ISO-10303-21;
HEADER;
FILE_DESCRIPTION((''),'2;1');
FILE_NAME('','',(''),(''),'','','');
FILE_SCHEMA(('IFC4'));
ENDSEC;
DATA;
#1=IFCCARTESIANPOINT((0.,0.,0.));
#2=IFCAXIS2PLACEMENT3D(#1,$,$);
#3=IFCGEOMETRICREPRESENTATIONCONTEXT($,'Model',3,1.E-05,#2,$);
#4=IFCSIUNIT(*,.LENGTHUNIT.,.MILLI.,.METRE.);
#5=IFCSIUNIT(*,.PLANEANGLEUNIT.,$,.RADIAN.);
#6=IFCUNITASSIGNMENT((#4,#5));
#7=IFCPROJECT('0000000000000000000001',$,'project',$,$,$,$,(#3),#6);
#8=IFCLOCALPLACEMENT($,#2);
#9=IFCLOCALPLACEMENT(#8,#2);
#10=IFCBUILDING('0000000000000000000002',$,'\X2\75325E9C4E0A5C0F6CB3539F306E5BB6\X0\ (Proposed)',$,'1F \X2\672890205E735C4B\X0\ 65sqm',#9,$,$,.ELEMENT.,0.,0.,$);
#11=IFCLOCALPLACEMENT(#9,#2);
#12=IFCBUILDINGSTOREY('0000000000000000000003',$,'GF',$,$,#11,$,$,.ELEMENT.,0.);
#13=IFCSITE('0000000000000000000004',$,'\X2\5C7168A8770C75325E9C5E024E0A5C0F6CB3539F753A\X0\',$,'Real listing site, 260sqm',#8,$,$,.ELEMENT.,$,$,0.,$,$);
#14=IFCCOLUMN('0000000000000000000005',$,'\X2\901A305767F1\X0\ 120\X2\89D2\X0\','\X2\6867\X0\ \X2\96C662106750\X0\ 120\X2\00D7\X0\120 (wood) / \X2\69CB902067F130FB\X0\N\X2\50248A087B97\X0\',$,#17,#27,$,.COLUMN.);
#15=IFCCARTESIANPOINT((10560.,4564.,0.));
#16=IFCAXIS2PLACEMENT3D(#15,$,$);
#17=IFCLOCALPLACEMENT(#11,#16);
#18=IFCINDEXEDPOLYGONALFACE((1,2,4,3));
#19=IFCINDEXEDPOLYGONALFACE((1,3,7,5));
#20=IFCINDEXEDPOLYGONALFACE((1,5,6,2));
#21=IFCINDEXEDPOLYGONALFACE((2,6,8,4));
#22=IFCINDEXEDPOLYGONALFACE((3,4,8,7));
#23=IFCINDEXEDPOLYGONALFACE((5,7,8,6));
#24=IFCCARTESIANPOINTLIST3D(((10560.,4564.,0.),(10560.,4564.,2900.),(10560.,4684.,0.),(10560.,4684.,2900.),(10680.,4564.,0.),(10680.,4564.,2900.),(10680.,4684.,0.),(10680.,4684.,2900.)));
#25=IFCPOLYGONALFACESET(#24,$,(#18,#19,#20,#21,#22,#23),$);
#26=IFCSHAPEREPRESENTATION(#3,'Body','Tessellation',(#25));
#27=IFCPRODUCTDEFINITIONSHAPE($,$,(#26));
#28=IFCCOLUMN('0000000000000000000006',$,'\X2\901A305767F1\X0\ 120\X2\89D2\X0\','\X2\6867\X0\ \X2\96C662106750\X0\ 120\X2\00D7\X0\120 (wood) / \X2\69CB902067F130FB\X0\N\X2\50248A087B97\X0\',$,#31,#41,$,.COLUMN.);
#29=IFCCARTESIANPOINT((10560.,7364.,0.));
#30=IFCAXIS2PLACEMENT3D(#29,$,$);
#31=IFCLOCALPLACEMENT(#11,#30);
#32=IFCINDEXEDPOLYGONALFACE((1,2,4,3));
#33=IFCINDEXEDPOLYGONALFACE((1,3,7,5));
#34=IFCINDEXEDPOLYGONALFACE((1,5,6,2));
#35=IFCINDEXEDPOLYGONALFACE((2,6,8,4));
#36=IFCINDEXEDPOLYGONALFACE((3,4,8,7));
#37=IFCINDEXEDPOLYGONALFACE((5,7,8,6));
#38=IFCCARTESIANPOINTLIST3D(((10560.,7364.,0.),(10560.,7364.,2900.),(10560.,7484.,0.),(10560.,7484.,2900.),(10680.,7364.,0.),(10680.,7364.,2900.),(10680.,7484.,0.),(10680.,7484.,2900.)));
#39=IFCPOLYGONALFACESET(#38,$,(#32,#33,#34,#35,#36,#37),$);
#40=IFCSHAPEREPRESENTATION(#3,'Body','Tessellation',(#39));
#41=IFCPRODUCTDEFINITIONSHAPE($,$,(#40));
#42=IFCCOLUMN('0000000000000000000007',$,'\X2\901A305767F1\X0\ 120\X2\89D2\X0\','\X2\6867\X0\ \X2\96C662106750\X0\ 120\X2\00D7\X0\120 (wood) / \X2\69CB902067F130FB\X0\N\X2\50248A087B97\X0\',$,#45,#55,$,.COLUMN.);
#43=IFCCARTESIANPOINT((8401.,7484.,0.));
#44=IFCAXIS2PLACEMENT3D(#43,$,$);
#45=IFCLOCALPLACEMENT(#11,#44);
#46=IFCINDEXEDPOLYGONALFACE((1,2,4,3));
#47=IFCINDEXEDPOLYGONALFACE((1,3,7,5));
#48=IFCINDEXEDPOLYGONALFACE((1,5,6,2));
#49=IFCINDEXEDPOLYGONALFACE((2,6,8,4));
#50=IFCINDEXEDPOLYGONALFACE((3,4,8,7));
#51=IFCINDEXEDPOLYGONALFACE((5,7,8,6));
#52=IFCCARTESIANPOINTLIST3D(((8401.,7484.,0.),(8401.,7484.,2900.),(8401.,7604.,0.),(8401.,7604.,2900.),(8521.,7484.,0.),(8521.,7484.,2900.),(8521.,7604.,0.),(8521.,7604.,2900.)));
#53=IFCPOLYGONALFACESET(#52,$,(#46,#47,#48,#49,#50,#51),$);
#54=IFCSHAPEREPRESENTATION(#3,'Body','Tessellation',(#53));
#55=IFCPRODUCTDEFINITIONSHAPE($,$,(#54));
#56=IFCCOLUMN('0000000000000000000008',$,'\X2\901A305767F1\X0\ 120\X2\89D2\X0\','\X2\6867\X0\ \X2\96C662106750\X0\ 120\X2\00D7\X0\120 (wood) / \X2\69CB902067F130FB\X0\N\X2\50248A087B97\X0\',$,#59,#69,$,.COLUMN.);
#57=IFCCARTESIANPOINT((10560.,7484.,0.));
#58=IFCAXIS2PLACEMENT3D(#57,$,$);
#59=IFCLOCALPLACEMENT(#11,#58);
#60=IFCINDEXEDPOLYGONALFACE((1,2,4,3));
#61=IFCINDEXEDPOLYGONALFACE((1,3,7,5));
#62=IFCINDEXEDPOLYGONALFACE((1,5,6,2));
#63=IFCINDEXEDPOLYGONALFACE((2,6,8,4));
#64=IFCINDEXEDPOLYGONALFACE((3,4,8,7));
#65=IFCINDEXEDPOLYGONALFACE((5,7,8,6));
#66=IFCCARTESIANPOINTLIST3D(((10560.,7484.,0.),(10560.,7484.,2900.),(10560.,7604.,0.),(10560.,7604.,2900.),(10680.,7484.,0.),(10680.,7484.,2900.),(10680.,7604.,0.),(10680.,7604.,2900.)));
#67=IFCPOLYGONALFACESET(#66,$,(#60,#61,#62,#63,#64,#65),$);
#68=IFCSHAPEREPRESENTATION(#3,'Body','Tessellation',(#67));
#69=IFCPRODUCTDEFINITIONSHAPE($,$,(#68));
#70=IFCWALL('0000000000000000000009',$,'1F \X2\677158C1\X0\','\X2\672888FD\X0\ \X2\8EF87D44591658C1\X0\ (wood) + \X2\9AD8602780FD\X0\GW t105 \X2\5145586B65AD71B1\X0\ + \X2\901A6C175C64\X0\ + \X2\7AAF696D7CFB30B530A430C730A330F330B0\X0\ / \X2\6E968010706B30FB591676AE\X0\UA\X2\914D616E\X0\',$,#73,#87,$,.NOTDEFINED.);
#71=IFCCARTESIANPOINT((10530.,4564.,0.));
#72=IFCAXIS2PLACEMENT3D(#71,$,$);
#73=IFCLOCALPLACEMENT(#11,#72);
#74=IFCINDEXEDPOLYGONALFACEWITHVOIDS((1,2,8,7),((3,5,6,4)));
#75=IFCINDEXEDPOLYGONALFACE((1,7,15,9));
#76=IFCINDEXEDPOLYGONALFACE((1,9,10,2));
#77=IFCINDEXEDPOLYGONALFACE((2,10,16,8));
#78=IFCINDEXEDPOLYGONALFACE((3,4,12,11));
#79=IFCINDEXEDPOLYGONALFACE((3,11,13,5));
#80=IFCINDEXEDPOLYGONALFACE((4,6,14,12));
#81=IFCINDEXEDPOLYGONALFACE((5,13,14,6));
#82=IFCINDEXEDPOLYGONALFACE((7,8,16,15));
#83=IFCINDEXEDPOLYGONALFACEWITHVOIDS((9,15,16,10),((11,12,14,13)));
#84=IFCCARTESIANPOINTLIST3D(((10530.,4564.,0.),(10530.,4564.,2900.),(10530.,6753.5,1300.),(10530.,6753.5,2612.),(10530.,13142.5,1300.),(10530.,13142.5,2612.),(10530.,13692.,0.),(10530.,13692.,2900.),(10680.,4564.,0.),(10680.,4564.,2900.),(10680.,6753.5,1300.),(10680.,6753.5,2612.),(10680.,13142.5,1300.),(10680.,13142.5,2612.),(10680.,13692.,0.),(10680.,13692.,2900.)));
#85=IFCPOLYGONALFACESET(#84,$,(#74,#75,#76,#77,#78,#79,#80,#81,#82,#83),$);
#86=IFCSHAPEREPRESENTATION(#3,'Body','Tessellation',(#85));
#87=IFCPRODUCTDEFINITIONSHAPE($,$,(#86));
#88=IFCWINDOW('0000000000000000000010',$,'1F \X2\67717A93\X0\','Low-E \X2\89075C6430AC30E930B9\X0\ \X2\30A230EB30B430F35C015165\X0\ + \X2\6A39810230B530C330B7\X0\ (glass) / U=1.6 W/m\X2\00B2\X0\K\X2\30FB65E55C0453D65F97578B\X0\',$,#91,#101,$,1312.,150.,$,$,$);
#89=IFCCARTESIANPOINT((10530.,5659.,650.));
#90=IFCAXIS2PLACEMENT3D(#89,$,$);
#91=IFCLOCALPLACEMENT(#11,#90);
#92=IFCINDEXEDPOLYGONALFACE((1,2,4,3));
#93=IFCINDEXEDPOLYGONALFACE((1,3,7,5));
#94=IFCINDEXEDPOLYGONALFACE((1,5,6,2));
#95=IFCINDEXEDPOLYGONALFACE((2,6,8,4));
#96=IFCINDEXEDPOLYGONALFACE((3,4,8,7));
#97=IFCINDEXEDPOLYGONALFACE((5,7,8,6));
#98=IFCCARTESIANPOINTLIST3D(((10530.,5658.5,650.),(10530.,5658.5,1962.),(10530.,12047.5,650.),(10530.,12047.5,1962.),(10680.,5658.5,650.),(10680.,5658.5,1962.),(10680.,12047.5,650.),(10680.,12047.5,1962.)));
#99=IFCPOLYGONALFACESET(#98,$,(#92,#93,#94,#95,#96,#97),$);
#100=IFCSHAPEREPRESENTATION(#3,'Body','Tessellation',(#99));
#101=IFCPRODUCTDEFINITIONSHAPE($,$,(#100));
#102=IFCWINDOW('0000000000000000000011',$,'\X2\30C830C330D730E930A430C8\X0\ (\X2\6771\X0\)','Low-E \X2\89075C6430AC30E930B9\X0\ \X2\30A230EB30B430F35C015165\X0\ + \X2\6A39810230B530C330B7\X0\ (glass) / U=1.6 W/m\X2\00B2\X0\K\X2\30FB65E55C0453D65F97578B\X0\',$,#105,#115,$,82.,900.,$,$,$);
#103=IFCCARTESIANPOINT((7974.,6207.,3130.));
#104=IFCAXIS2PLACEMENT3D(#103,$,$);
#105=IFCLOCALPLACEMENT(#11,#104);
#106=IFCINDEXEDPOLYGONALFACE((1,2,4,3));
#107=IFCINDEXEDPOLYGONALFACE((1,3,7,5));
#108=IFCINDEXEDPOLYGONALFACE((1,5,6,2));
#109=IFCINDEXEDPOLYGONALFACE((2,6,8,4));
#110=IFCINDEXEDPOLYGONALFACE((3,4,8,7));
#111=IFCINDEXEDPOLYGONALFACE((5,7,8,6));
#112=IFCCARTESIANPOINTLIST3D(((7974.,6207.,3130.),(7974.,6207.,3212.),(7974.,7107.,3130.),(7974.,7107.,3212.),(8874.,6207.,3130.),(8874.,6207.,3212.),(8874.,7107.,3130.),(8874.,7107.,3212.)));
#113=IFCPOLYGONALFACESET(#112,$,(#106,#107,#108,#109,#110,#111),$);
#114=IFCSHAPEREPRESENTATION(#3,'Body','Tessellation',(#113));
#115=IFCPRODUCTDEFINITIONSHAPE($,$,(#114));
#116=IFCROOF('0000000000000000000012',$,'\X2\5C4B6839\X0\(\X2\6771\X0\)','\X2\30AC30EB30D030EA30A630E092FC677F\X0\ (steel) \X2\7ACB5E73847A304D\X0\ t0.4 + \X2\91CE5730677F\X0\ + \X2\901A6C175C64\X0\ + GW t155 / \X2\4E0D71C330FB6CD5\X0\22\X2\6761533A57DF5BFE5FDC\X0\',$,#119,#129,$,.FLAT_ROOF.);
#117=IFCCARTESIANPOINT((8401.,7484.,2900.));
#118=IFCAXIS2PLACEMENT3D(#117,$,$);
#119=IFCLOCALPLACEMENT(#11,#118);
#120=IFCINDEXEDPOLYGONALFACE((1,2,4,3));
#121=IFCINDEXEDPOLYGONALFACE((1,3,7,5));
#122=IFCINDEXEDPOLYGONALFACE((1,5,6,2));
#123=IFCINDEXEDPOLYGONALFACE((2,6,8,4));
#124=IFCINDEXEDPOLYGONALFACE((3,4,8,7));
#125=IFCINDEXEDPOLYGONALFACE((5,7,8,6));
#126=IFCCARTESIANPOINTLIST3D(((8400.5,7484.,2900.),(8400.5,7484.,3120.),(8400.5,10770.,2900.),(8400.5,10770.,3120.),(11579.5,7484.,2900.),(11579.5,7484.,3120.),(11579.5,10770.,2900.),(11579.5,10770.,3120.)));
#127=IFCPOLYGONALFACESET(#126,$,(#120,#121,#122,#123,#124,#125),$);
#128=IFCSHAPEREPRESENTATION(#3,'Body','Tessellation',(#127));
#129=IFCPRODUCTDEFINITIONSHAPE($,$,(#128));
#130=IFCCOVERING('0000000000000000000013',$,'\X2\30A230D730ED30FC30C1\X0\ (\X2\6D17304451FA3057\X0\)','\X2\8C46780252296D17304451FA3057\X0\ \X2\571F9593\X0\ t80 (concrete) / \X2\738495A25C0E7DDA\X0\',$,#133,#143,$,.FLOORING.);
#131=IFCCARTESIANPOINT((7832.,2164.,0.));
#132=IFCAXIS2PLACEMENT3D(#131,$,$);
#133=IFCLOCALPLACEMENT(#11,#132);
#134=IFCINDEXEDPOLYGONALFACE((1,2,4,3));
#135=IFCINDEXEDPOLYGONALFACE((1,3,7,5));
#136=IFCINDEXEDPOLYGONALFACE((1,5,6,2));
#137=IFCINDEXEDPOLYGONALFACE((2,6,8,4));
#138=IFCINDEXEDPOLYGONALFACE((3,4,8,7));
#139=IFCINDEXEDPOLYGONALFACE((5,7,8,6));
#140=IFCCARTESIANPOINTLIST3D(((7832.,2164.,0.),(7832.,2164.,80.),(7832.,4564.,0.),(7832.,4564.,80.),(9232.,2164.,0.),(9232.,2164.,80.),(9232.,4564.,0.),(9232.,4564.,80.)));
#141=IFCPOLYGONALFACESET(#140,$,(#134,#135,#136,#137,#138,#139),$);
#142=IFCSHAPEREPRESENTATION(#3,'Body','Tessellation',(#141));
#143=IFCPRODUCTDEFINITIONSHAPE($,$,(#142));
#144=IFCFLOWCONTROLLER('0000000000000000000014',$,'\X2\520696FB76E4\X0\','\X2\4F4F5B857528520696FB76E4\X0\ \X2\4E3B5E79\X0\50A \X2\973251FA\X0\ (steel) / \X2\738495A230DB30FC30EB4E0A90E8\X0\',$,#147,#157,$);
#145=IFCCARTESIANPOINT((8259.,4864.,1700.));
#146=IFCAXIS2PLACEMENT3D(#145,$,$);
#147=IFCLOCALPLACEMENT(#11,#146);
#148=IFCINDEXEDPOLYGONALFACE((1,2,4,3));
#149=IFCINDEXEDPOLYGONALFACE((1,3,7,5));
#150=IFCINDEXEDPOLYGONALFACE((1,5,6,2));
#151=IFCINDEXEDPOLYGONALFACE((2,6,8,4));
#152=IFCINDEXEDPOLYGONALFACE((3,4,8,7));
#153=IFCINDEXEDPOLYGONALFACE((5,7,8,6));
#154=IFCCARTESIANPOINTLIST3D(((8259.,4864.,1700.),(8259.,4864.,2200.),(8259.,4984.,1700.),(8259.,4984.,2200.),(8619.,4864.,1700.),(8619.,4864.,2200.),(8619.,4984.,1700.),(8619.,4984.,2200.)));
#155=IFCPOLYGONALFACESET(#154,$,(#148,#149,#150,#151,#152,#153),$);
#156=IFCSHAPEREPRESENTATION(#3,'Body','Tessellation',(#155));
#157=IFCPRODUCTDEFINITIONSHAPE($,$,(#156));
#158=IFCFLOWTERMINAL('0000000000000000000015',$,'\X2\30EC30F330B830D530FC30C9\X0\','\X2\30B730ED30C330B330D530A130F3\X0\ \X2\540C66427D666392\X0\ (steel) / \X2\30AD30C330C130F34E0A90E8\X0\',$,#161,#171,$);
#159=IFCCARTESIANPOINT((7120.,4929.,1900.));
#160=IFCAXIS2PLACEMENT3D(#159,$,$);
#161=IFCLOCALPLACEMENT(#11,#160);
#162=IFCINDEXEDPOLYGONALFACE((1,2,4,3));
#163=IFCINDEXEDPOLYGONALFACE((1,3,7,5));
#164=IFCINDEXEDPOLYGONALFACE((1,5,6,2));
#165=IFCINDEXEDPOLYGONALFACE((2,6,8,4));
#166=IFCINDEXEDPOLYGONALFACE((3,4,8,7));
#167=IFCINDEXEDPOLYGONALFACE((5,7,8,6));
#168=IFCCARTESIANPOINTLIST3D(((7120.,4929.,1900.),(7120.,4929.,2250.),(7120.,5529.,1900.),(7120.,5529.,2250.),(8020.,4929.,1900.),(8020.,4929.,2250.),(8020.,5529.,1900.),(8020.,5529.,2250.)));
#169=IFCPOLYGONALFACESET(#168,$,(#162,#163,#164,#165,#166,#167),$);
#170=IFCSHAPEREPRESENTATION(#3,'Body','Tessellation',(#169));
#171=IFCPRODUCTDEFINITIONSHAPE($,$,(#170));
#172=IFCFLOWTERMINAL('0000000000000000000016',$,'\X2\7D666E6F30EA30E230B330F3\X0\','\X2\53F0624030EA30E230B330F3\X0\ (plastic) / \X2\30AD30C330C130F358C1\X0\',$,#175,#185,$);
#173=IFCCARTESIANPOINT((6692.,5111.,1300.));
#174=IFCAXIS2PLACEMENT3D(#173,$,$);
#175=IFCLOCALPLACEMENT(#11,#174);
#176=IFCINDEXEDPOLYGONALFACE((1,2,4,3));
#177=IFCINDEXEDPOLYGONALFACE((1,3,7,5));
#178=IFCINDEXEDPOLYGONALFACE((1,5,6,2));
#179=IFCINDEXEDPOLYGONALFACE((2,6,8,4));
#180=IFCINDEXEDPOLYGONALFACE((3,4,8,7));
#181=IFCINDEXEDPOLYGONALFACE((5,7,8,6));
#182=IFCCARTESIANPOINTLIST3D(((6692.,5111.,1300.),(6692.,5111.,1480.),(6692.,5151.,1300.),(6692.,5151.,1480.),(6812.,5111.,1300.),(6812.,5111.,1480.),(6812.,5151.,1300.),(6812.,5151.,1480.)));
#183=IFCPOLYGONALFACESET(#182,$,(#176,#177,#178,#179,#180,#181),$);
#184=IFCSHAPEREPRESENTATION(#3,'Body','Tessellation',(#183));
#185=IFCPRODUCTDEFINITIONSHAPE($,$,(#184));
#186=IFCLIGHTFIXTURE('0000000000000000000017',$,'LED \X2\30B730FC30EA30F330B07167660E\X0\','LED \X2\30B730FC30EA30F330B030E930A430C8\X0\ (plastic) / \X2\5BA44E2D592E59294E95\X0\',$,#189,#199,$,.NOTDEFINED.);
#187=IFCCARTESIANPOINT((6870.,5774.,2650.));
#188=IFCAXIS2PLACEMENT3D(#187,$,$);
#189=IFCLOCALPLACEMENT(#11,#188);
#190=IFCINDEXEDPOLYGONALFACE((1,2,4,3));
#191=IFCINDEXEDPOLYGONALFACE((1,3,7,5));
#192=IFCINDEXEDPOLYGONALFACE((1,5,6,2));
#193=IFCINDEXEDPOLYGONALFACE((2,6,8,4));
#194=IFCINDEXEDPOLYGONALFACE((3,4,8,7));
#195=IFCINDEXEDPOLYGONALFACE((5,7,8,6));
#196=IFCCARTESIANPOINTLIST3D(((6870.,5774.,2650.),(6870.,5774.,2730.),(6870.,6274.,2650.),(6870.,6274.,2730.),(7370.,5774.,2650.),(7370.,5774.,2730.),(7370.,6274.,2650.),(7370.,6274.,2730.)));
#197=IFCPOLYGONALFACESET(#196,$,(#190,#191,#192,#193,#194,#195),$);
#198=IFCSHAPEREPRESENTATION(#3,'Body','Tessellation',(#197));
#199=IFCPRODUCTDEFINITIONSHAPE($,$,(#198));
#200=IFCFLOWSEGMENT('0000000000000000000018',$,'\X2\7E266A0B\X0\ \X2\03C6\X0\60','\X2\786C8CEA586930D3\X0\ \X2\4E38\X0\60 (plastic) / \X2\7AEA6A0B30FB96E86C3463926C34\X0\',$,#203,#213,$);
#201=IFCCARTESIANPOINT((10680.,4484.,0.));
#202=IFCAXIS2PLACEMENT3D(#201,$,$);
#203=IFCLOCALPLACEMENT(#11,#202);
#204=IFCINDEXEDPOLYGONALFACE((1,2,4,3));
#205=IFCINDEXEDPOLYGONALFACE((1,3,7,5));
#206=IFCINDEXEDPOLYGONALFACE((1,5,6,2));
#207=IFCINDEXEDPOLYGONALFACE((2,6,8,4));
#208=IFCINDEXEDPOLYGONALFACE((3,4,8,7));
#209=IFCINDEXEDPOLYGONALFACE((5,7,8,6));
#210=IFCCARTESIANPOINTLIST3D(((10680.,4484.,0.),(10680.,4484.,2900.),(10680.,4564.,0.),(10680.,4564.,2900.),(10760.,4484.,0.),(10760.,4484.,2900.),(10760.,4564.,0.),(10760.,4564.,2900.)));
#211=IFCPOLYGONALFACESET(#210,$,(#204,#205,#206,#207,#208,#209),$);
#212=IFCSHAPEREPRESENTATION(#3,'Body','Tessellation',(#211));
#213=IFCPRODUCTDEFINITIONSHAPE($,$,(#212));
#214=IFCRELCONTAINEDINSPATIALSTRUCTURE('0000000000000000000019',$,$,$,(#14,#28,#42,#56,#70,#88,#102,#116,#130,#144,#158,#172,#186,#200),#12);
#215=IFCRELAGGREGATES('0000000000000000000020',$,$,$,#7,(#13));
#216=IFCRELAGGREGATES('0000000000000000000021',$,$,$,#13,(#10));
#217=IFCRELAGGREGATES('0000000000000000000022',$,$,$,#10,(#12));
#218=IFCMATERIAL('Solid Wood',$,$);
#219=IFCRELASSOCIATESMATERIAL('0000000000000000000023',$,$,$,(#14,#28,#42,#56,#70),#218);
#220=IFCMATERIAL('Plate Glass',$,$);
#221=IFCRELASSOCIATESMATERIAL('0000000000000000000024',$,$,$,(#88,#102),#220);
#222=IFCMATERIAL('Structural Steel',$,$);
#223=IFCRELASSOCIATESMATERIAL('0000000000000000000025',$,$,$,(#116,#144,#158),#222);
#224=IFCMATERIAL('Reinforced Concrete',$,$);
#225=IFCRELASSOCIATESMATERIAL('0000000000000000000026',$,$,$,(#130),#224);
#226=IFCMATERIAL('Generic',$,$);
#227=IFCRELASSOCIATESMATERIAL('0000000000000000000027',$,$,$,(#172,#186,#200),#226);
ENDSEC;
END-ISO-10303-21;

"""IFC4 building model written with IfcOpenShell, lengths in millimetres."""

from ifc_helpers import new_model, si_unit, frame, frame_2d, origin, place, context, project, spatial, rectangle, extrude, material, element, fill, save


model = new_model("IFC4")

# Units and contexts
model_context = context("Model", 3, precision=1e-05, world=origin())
ifc_project = project(units=[si_unit("LENGTHUNIT", "METRE", prefix="MILLI"), si_unit("PLANEANGLEUNIT", "RADIAN")], contexts=[model_context])

# Site, building, storey
site_placement = place(None, origin())
site = spatial("IfcSite", under=ifc_project, at=site_placement, Name="山梨県甲府市上小河原町", ObjectType="Real listing site, 260sqm", CompositionType="ELEMENT", RefElevation=0.0)
building_placement = place(site_placement, origin())
building = spatial("IfcBuilding", under=site, at=building_placement, Name="甲府上小河原の家 (Proposed)", ObjectType="1F 木造平屋 65sqm", CompositionType="ELEMENT", ElevationOfRefHeight=0.0, ElevationOfTerrain=0.0)
storey_placement = place(building_placement, origin())
storey = spatial("IfcBuildingStorey", under=building, at=storey_placement, Name="GF", CompositionType="ELEMENT", Elevation=0.0)

# Columns
ifc_material_1 = material(Name="Solid Wood")
column_1_placement = place(storey_placement, frame((10560.0, 4564.0, 0.0)))
element("IfcColumn", 1, at=column_1_placement, inside=storey, material=ifc_material_1, Name="通し柱 120角", Description="桧 集成材 120×120 (wood) / 構造柱・N値計算", PredefinedType="COLUMN", context=model_context, shape_type="SweptSolid", body=[
    extrude(rectangle(XDim=120.0, YDim=120.0, at=frame_2d((60.0, 60.0))), frame((10560.0, 4564.0, 0.0)), (0.0, 0.0, 1.0), 2900.0),
])
column_2_placement = place(storey_placement, frame((10560.0, 7364.0, 0.0)))
element("IfcColumn", 2, at=column_2_placement, inside=storey, material=ifc_material_1, Name="通し柱 120角", Description="桧 集成材 120×120 (wood) / 構造柱・N値計算", PredefinedType="COLUMN", context=model_context, shape_type="SweptSolid", body=[
    extrude(rectangle(XDim=120.0, YDim=120.0, at=frame_2d((60.0, 60.0))), frame((10560.0, 7364.0, 0.0)), (0.0, 0.0, 1.0), 2900.0),
])
column_3_placement = place(storey_placement, frame((8401.0, 7484.0, 0.0)))
element("IfcColumn", 3, at=column_3_placement, inside=storey, material=ifc_material_1, Name="通し柱 120角", Description="桧 集成材 120×120 (wood) / 構造柱・N値計算", PredefinedType="COLUMN", context=model_context, shape_type="SweptSolid", body=[
    extrude(rectangle(XDim=120.0, YDim=120.0, at=frame_2d((60.0, 60.0))), frame((8401.0, 7484.0, 0.0)), (0.0, 0.0, 1.0), 2900.0),
])
column_4_placement = place(storey_placement, frame((10560.0, 7484.0, 0.0)))
element("IfcColumn", 4, at=column_4_placement, inside=storey, material=ifc_material_1, Name="通し柱 120角", Description="桧 集成材 120×120 (wood) / 構造柱・N値計算", PredefinedType="COLUMN", context=model_context, shape_type="SweptSolid", body=[
    extrude(rectangle(XDim=120.0, YDim=120.0, at=frame_2d((60.0, 60.0))), frame((10560.0, 7484.0, 0.0)), (0.0, 0.0, 1.0), 2900.0),
])

# Wall, opening, window
wall_1_placement = place(storey_placement, frame((10530.0, 4564.0, 0.0)))
wall_1 = element("IfcWall", 5, at=wall_1_placement, inside=storey, material=ifc_material_1, Name="1F 東壁", Description="木製 軸組外壁 (wood) + 高性能GW t105 充填断熱 + 通気層 + 窯業系サイディング / 準耐火・外皮UA配慮", PredefinedType="NOTDEFINED", context=model_context, shape_type="SweptSolid", body=[
    extrude(rectangle(XDim=150.0, YDim=9128.0, at=frame_2d((75.0, 4564.0))), frame((10530.0, 4564.0, 0.0)), (0.0, 0.0, 1.0), 2900.0),
])
opening_placement = place(storey_placement, frame((10530.0, 5659.0, 650.0)))
opening = element("IfcOpeningElement", 6, at=opening_placement, cuts=wall_1, PredefinedType="NOTDEFINED", context=model_context, shape_type="SweptSolid", body=[
    extrude(rectangle(XDim=150.0, YDim=6389.0, at=frame_2d((75.0, 3194.0))), frame((10530.0, 5659.0, 650.0)), (0.0, 0.0, 1.0), 1312.0),
])
ifc_material_2 = material(Name="Plate Glass")
window_1_placement = place(storey_placement, frame((10530.0, 5659.0, 650.0)))
window_1 = element("IfcWindow", 7, at=window_1_placement, inside=storey, material=ifc_material_2, Name="1F 東窓", Description="Low-E 複層ガラス アルゴン封入 + 樹脂サッシ (glass) / U=1.6 W/m²K・日射取得型", OverallHeight=1312.0, OverallWidth=150.0, context=model_context, shape_type="SweptSolid", body=[
    extrude(rectangle(XDim=150.0, YDim=6389.0, at=frame_2d((75.0, 3194.0))), frame((10530.0, 5659.0, 650.0)), (0.0, 0.0, 1.0), 1312.0),
])
fill(opening, window_1)

# Window
window_2_placement = place(storey_placement, frame((7974.0, 6207.0, 3130.0)))
element("IfcWindow", 8, at=window_2_placement, inside=storey, material=ifc_material_2, Name="トップライト (東)", Description="Low-E 複層ガラス アルゴン封入 + 樹脂サッシ (glass) / U=1.6 W/m²K・日射取得型", OverallHeight=82.0, OverallWidth=900.0, context=model_context, shape_type="SweptSolid", body=[
    extrude(rectangle(XDim=900.0, YDim=900.0, at=frame_2d((450.0, 450.0))), frame((7974.0, 6207.0, 3130.0)), (0.0, 0.0, 1.0), 82.0),
])

# Roof
ifc_material_3 = material(Name="Structural Steel")
roof_placement = place(storey_placement, frame((8401.0, 7484.0, 2900.0)))
element("IfcRoof", 9, at=roof_placement, inside=storey, material=ifc_material_3, Name="屋根(東)", Description="ガルバリウム鋼板 (steel) 立平葺き t0.4 + 野地板 + 通気層 + GW t155 / 不燃・法22条区域対応", PredefinedType="FLAT_ROOF", context=model_context, shape_type="SweptSolid", body=[
    extrude(rectangle(XDim=3179.0, YDim=3286.0, at=frame_2d((1589.0, 1643.0))), frame((8401.0, 7484.0, 2900.0)), (0.0, 0.0, 1.0), 220.0),
])

# Covering
ifc_material_4 = material(Name="Reinforced Concrete")
covering_placement = place(storey_placement, frame((7832.0, 2164.0, 0.0)))
element("IfcCovering", 10, at=covering_placement, inside=storey, material=ifc_material_4, Name="アプローチ (洗い出し)", Description="豆砂利洗い出し 土間 t80 (concrete) / 玄関導線", PredefinedType="FLOORING", context=model_context, shape_type="SweptSolid", body=[
    extrude(rectangle(XDim=1400.0, YDim=2400.0, at=frame_2d((700.0, 1200.0))), frame((7832.0, 2164.0, 0.0)), (0.0, 0.0, 1.0), 80.0),
])

# Flow controller
flow_controller_placement = place(storey_placement, frame((8259.0, 4864.0, 1700.0)))
element("IfcFlowController", 11, at=flow_controller_placement, inside=storey, material=ifc_material_3, Name="分電盤", Description="住宅用分電盤 主幹50A 露出 (steel) / 玄関ホール上部", context=model_context, shape_type="SweptSolid", body=[
    extrude(rectangle(XDim=360.0, YDim=120.0, at=frame_2d((180.0, 60.0))), frame((8259.0, 4864.0, 1700.0)), (0.0, 0.0, 1.0), 500.0),
])

# Flow terminals
flow_terminal_1_placement = place(storey_placement, frame((7120.0, 4929.0, 1900.0)))
element("IfcFlowTerminal", 12, at=flow_terminal_1_placement, inside=storey, material=ifc_material_3, Name="レンジフード", Description="シロッコファン 同時給排 (steel) / キッチン上部", context=model_context, shape_type="SweptSolid", body=[
    extrude(rectangle(XDim=900.0, YDim=600.0, at=frame_2d((450.0, 300.0))), frame((7120.0, 4929.0, 1900.0)), (0.0, 0.0, 1.0), 350.0),
])
ifc_material_5 = material(Name="Generic")
flow_terminal_2_placement = place(storey_placement, frame((6692.0, 5111.0, 1300.0)))
element("IfcFlowTerminal", 13, at=flow_terminal_2_placement, inside=storey, material=ifc_material_5, Name="給湯リモコン", Description="台所リモコン (plastic) / キッチン壁", context=model_context, shape_type="SweptSolid", body=[
    extrude(rectangle(XDim=120.0, YDim=40.0, at=frame_2d((60.0, 20.0))), frame((6692.0, 5111.0, 1300.0)), (0.0, 0.0, 1.0), 180.0),
])

# Light fixture
light_fixture_placement = place(storey_placement, frame((6870.0, 5774.0, 2650.0)))
element("IfcLightFixture", 14, at=light_fixture_placement, inside=storey, material=ifc_material_5, Name="LED シーリング照明", Description="LED シーリングライト (plastic) / 室中央天井", PredefinedType="NOTDEFINED", context=model_context, shape_type="SweptSolid", body=[
    extrude(rectangle(XDim=500.0, YDim=500.0, at=frame_2d((250.0, 250.0))), frame((6870.0, 5774.0, 2650.0)), (0.0, 0.0, 1.0), 80.0),
])

# Flow segment
flow_segment_placement = place(storey_placement, frame((10680.0, 4484.0, 0.0)))
element("IfcFlowSegment", 15, at=flow_segment_placement, inside=storey, material=ifc_material_5, Name="縦樋 φ60", Description="硬質塩ビ 丸60 (plastic) / 竪樋・雨水排水", context=model_context, shape_type="SweptSolid", body=[
    extrude(rectangle(XDim=80.0, YDim=80.0, at=frame_2d((40.0, 40.0))), frame((10680.0, 4484.0, 0.0)), (0.0, 0.0, 1.0), 2900.0),
])

save(model, "model.ifc")
